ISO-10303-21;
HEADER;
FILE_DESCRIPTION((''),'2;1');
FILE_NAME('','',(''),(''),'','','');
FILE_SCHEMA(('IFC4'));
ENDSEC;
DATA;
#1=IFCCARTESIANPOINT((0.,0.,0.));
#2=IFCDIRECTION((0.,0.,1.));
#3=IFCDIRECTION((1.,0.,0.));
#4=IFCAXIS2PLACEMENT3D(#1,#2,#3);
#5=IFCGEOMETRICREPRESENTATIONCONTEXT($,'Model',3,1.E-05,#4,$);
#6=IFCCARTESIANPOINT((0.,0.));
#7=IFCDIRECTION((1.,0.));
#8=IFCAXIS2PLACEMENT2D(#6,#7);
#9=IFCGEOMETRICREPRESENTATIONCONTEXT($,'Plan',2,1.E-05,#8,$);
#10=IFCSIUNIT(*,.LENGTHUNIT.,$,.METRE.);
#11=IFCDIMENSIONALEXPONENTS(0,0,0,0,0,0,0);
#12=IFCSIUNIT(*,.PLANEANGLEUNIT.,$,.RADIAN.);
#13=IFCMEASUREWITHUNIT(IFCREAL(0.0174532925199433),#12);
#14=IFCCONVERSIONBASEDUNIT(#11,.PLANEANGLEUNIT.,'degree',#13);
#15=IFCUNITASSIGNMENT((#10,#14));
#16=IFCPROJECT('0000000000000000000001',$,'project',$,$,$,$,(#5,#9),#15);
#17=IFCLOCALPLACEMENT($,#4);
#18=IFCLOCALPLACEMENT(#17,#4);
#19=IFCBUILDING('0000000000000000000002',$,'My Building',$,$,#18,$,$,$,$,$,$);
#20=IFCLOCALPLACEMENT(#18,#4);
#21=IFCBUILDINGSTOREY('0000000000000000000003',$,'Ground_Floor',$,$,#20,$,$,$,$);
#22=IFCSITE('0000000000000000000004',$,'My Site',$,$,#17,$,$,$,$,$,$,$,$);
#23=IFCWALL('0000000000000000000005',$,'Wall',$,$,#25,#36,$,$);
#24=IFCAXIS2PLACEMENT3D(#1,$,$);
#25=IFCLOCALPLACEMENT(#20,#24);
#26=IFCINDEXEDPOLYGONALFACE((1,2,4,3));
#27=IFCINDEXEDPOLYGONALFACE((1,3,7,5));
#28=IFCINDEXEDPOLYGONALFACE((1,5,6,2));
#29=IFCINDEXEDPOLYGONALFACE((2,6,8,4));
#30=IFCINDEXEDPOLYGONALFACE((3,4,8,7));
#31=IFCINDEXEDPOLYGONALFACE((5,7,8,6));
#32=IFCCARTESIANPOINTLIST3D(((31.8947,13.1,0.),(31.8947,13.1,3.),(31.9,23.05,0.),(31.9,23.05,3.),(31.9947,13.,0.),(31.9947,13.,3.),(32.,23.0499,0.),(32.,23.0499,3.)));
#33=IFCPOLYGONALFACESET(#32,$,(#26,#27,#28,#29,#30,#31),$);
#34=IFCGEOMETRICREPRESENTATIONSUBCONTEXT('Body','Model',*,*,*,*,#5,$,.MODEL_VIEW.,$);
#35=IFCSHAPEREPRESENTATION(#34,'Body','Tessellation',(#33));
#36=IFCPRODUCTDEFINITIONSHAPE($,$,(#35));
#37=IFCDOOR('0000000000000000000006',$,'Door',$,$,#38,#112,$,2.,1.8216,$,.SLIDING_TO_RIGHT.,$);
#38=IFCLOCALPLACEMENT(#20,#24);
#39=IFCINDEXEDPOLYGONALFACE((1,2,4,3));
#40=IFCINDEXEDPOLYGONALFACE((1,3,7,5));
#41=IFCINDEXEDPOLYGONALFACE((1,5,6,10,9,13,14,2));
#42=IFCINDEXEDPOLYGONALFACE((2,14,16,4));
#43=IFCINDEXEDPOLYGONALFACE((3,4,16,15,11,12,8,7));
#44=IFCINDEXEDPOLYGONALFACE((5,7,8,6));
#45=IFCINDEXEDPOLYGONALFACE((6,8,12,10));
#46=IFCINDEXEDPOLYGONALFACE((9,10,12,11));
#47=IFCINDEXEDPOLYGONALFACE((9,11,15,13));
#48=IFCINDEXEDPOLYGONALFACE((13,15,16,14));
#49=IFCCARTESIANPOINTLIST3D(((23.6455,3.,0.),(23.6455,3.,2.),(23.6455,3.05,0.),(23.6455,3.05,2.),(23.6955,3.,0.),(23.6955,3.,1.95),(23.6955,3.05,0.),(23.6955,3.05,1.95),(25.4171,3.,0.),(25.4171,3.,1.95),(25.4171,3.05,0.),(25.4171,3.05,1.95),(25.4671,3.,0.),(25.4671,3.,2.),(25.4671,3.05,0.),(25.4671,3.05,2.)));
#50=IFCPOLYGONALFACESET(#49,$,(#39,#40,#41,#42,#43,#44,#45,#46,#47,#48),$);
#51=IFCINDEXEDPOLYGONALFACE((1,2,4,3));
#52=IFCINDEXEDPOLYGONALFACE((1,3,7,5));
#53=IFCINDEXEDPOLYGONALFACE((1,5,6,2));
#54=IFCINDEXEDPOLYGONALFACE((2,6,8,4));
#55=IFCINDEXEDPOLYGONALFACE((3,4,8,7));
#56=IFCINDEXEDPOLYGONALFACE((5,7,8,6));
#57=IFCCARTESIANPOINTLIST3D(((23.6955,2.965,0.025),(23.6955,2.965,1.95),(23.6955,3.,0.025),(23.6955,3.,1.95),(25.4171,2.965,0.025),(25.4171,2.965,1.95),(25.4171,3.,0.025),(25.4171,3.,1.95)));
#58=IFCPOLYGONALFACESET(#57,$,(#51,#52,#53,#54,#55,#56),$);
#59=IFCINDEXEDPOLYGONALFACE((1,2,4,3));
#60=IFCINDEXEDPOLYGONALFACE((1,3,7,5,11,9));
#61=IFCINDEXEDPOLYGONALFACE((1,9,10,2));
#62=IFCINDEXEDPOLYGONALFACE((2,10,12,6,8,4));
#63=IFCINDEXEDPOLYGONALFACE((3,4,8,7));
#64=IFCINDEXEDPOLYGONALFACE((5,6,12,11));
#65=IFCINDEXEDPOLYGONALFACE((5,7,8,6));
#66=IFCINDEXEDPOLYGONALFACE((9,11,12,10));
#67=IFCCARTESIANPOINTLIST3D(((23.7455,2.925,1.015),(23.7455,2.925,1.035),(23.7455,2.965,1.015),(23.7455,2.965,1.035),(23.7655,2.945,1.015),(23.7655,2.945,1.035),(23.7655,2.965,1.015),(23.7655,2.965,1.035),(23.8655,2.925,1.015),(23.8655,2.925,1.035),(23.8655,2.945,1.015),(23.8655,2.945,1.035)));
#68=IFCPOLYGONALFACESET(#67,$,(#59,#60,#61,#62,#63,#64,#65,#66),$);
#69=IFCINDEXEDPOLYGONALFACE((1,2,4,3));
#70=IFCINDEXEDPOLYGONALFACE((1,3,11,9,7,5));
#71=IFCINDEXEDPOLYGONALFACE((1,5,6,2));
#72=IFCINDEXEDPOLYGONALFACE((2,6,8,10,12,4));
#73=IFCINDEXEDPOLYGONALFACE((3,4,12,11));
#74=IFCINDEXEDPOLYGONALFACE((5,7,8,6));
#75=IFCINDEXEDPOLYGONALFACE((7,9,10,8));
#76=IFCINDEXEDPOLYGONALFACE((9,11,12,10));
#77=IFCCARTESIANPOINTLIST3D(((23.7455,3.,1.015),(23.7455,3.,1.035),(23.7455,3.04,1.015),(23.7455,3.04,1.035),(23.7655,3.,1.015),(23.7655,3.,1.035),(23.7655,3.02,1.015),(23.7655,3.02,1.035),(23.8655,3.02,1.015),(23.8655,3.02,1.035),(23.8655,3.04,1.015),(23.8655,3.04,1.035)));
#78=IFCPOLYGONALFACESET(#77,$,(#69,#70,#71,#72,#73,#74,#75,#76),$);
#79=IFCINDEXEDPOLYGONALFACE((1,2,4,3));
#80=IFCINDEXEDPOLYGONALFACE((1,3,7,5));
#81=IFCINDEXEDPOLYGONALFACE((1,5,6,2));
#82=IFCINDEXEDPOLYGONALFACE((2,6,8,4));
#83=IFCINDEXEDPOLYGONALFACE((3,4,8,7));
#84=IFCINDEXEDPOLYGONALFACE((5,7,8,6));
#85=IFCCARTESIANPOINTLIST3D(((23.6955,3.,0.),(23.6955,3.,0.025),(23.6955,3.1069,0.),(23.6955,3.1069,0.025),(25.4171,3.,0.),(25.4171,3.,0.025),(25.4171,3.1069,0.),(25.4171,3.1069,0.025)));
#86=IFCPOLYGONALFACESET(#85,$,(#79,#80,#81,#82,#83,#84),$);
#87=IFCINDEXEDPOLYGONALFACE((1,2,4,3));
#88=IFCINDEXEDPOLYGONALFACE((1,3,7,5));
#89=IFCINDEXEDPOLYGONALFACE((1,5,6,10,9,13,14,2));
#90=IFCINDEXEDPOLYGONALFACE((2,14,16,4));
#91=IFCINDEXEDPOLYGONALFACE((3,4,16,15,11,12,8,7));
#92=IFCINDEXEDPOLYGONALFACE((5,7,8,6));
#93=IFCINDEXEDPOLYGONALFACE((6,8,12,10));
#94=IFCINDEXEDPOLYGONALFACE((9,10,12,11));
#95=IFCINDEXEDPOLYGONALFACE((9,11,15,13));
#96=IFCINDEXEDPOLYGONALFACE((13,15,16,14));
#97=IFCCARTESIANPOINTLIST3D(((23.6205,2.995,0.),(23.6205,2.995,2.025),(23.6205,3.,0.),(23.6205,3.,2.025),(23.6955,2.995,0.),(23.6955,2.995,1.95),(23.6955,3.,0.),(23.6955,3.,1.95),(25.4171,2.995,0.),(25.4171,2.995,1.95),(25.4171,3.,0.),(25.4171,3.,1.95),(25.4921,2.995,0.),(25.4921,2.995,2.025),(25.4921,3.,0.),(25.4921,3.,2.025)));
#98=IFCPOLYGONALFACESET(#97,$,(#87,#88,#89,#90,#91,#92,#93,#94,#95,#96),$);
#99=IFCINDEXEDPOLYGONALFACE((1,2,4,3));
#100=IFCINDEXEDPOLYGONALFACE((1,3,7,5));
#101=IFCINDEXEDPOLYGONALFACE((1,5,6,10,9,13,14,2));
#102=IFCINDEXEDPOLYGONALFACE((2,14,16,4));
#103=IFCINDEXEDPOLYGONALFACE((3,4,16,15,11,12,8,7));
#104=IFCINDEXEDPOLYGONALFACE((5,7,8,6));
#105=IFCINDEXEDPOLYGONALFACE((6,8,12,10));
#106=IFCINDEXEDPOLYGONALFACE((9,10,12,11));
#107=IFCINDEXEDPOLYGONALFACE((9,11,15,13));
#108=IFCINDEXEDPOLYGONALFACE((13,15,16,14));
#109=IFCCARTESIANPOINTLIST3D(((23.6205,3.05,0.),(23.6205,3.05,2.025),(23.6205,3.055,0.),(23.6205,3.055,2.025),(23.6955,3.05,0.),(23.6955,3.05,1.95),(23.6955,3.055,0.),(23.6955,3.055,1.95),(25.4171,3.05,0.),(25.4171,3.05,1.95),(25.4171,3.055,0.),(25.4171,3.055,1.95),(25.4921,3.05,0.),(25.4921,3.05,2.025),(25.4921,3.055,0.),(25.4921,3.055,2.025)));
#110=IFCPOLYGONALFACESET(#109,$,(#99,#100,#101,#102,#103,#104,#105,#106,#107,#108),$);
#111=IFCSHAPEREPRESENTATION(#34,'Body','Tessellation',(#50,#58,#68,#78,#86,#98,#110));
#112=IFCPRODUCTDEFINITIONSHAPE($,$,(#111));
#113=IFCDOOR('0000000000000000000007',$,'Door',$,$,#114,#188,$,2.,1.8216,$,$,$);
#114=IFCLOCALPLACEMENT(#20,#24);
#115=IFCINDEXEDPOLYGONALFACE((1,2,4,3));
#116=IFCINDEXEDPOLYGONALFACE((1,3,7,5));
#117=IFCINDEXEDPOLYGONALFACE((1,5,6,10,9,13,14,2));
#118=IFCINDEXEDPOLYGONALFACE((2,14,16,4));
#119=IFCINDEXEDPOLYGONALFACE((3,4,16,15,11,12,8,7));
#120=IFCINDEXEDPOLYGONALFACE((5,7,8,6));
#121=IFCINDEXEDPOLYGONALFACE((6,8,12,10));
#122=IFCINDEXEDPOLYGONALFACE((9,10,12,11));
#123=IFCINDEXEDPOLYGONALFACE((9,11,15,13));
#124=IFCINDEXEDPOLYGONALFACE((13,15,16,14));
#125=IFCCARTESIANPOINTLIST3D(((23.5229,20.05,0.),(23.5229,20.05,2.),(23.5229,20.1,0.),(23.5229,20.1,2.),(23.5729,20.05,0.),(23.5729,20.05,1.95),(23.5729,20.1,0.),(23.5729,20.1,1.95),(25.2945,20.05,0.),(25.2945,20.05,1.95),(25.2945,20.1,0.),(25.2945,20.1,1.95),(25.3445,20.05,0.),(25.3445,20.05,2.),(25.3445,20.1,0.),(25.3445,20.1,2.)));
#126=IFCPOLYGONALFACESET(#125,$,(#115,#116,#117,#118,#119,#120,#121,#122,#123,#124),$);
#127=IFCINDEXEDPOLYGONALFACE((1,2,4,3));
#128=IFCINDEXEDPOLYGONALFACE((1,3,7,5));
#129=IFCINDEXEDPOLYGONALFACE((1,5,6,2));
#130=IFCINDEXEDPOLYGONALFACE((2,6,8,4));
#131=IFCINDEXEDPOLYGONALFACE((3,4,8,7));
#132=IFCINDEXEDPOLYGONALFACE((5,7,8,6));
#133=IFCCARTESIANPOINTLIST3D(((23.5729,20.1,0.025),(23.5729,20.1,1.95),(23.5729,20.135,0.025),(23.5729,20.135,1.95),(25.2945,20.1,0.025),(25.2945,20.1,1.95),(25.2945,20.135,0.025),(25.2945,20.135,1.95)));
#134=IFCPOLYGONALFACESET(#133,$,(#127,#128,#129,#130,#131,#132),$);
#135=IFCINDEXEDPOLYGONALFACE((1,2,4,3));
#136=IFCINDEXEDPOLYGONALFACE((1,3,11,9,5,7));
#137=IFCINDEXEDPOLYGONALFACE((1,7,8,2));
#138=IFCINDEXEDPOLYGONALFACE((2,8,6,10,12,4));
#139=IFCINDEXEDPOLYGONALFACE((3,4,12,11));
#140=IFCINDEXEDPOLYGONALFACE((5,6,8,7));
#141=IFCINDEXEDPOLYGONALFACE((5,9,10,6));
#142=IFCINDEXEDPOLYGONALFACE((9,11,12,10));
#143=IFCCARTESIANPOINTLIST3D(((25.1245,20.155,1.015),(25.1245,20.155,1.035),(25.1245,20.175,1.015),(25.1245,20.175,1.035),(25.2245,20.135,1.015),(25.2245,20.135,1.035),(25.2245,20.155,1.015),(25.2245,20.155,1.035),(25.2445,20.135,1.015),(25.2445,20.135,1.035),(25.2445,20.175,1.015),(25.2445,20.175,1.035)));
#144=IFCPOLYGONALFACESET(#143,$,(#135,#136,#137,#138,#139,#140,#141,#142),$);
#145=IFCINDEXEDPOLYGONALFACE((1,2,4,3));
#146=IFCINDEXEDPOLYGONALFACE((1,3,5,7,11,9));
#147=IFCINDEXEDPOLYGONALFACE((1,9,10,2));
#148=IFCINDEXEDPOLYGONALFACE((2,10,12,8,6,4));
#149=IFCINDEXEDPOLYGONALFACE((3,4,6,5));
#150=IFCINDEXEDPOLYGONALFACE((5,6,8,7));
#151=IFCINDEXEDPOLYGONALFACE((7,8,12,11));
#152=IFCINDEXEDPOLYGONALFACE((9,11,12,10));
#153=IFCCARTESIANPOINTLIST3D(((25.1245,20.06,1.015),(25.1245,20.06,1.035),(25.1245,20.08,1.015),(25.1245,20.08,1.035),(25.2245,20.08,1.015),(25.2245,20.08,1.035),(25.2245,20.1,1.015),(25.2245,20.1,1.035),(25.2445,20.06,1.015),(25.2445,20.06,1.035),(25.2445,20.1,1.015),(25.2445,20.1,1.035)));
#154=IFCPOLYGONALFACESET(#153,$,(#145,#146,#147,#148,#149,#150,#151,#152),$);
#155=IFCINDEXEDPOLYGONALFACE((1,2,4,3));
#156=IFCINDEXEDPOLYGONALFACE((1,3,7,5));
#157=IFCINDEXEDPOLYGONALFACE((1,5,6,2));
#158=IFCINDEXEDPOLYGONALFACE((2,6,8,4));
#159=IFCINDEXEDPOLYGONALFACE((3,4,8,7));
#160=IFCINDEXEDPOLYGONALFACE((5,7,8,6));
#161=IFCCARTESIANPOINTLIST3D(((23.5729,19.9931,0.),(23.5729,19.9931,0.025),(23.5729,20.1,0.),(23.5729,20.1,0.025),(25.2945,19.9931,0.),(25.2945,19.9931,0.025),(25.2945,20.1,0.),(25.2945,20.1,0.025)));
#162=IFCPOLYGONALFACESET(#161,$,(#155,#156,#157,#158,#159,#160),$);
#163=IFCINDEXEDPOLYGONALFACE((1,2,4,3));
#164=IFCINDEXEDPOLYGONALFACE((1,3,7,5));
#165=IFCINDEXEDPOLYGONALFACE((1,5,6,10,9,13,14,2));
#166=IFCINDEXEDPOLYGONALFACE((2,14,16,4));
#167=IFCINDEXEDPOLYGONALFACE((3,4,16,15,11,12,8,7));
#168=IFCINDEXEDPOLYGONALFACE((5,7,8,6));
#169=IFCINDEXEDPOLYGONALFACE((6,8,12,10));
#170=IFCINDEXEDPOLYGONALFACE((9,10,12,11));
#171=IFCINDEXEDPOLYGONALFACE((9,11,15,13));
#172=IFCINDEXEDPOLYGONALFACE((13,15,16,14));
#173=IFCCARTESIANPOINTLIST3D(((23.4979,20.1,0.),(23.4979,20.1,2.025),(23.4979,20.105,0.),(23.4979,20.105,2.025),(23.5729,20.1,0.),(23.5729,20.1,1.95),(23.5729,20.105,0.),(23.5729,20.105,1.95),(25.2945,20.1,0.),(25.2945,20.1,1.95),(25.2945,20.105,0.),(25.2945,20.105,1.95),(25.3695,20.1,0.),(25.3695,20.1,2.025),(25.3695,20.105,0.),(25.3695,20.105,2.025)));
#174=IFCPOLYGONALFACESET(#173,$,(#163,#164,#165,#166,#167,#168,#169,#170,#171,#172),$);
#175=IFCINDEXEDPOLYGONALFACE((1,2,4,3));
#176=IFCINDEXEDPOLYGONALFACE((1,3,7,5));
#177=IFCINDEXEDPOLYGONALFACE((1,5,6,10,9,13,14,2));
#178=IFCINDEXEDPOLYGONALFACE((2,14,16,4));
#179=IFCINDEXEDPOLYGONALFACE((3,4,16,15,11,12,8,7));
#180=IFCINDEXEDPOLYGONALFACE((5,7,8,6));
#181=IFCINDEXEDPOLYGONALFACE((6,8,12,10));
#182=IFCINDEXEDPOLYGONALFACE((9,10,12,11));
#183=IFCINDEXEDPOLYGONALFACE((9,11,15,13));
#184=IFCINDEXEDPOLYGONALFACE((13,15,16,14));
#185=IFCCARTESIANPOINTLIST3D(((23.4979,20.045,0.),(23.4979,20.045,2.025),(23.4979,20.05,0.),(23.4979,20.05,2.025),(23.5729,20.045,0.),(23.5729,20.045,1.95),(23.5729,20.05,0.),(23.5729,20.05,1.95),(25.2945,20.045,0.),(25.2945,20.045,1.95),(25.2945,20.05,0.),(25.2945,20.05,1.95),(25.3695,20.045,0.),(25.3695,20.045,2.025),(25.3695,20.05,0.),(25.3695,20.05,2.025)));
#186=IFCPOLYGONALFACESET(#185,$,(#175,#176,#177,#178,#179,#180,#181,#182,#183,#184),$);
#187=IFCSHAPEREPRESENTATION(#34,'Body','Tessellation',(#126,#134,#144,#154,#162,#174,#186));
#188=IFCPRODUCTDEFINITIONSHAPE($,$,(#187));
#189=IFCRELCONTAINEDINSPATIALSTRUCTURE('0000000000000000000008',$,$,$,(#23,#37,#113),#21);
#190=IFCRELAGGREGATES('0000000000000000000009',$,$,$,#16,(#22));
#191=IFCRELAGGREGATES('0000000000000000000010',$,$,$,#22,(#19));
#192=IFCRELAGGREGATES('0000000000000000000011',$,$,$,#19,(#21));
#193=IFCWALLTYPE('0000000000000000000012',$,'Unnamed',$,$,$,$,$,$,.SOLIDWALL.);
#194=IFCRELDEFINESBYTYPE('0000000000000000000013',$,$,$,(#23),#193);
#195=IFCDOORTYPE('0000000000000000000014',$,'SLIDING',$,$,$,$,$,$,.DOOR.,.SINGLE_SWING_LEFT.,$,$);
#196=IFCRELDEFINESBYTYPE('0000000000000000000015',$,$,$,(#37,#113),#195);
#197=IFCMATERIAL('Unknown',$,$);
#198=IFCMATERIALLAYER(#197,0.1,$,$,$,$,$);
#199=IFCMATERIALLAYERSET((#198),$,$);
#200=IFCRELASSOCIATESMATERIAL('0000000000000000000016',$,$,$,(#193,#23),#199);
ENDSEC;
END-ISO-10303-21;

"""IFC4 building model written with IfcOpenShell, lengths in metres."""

from ifc_helpers import new_model, entity, si_unit, converted_unit, frame, origin_with_axes, origin_2d_with_axis, place, context, subcontext, project, spatial, line, indexed_curve, outline, extrude, shape, source, transform, mapped, material, layer, layer_set, layer_usage, type_object, type_shapes, element, save


model = new_model("IFC4")

# Units and contexts
model_context = context("Model", 3, precision=1e-05, world=origin_with_axes())
plan_context = context("Plan", 2, precision=1e-05, world=origin_2d_with_axis())
body_context_1 = subcontext(model_context, "Body", "Model", "MODEL_VIEW")
body_context_2 = subcontext(plan_context, "Body", "Plan", "PLAN_VIEW")
ifc_project = project(units=[si_unit("LENGTHUNIT", "METRE"), converted_unit("PLANEANGLEUNIT", "degree", entity("IfcReal", 0.0174532925199433), si_unit("PLANEANGLEUNIT", "RADIAN"), dimensions=[0, 0, 0, 0, 0, 0, 0])], contexts=[model_context, plan_context])

# Site, building, storey
site_placement = place(None, origin_with_axes())
site = spatial("IfcSite", under=ifc_project, at=site_placement, Name="My Site")
building_placement = place(site_placement, origin_with_axes())
building = spatial("IfcBuilding", under=site, at=building_placement, Name="My Building")
storey_placement = place(building_placement, origin_with_axes())
storey = spatial("IfcBuildingStorey", under=building, at=storey_placement, Name="Ground_Floor")

# Shared definitions
ifc_material = material(Name="Unknown")
ifc_layer = layer(ifc_material, 0.1)
ifc_layer_set = layer_set([ifc_layer])
wall_type = type_object("IfcWallType", Name="Unnamed", PredefinedType="SOLIDWALL", material=ifc_layer_set)

# Shared definitions
door_type_1 = type_object("IfcDoorType", Name="SLIDING", OperationType="SINGLE_SWING_LEFT", PredefinedType="DOOR")
shared_shape_1 = source(origin_with_axes(), body_context_1, "Body", "SweptSolid", [
    extrude(outline(indexed_curve([(0.0, 0.0), (0.0, 2.0), (1.8216, 2.0), (1.8216, 0.0), (1.7716, 0.0), (1.7716, 1.95), (0.05, 1.95), (0.05, 0.0)], segments=[line(1, 2, 3, 4, 5, 6, 7, 8, 1)])), frame((0.0, 0.0, 0.0), z_axis=(0.0, -1.0, 0.0), x_axis=(1.0, 0.0, 0.0)), (0.0, 0.0, -1.0), 0.05),
    extrude(outline(indexed_curve([(0.0, 0.0), (1.7216, 0.0), (1.7216, 0.035), (0.0, 0.035)], segments=[line(1, 2, 3, 4, 1)])), frame((0.05, -0.035, 0.025), z_axis=(0.0, 0.0, 1.0), x_axis=(1.0, 0.0, 0.0)), (0.0, 0.0, 1.0), 1.925),
    extrude(outline(indexed_curve([(0.0, 0.0), (0.0, -0.04), (0.12, -0.04), (0.12, -0.02), (0.02, -0.02), (0.02, 0.0)], segments=[line(1, 2, 3, 4, 5, 6, 1)])), frame((0.1, -0.035, 1.015), z_axis=(0.0, 0.0, 1.0), x_axis=(1.0, 0.0, 0.0)), (0.0, 0.0, 1.0), 0.02),
    extrude(outline(indexed_curve([(0.0, 0.0), (0.0, 0.04), (0.12, 0.04), (0.12, 0.02), (0.02, 0.02), (0.02, 0.0)], segments=[line(1, 2, 3, 4, 5, 6, 1)])), frame((0.1, 0.0, 1.015), z_axis=(0.0, 0.0, 1.0), x_axis=(1.0, 0.0, 0.0)), (0.0, 0.0, 1.0), 0.02),
    extrude(outline(indexed_curve([(0.0, 0.0), (1.7216, 0.0), (1.7216, 0.1069), (0.0, 0.1069)], segments=[line(1, 2, 3, 4, 1)])), frame((0.05, 0.0, 0.0), z_axis=(0.0, 0.0, 1.0), x_axis=(1.0, 0.0, 0.0)), (0.0, 0.0, 1.0), 0.025),
    extrude(outline(indexed_curve([(0.0, 0.0), (0.0, 2.025), (1.8716, 2.025), (1.8716, 0.0), (1.7966, 0.0), (1.7966, 1.95), (0.075, 1.95), (0.075, 0.0)], segments=[line(1, 2, 3, 4, 5, 6, 7, 8, 1)])), frame((-0.025, -0.005, 0.0), z_axis=(0.0, -1.0, 0.0), x_axis=(1.0, 0.0, 0.0)), (0.0, 0.0, -1.0), 0.005),
    extrude(outline(indexed_curve([(0.0, 0.0), (0.0, 2.025), (1.8716, 2.025), (1.8716, 0.0), (1.7966, 0.0), (1.7966, 1.95), (0.075, 1.95), (0.075, 0.0)], segments=[line(1, 2, 3, 4, 5, 6, 7, 8, 1)])), frame((-0.025, 0.05, 0.0), z_axis=(0.0, -1.0, 0.0), x_axis=(1.0, 0.0, 0.0)), (0.0, 0.0, -1.0), 0.005),
])
shared_shape_2 = source(origin_with_axes(), body_context_2, "Body", "Curve2D", [
    entity("IfcIndexedPolyCurve", entity("IfcCartesianPointList2D", [[0.0, 0.0], [0.05, 0.0], [0.05, 0.05], [0.0, 0.05]]), [entity("IfcLineIndex", [1, 2, 3, 4, 1])]),
    entity("IfcIndexedPolyCurve", entity("IfcCartesianPointList2D", [[1.8216, 0.0], [1.7716, 0.0], [1.7716, 0.05], [1.8216, 0.05]]), [entity("IfcLineIndex", [1, 2, 3, 4, 1])]),
    entity("IfcIndexedPolyCurve", entity("IfcCartesianPointList2D", [[2.6325, -0.035], [0.9108, -0.035], [0.9108, 0.0], [2.6325, 0.0]]), [entity("IfcLineIndex", [1, 2, 3, 4, 1])]),
])
type_shapes(door_type_1, [shared_shape_1, shared_shape_2])

# Wall
ifc_layer_usage_1 = layer_usage(ifc_layer_set, "AXIS2", "POSITIVE", 0.0)
wall_1_placement = place(storey_placement, frame((31.9, 23.05, 0.0), z_axis=(0.0, 0.0, 1.0), x_axis=(-0.000532, -1.0, 0.0)))
element("IfcWall", 1, at=wall_1_placement, inside=storey, type_object=wall_type, material=ifc_layer_usage_1, Name="Wall", context=body_context_1, shape_type="SweptSolid", body=[
    extrude(outline(indexed_curve([(0.0, 0.0), (0.0, 0.1), (10.0499, 0.1), (9.95, 0.0)], segments=[line(1, 2, 3, 4, 1)])), origin_with_axes(), (0.0, 0.0, 1.0), 3.0),
])

# Doors
door_1_placement = place(storey_placement, frame((23.6455, 3.0, 0.0), z_axis=(0.0, 0.0, 1.0), x_axis=(1.0, 0.0, 0.0)))
element("IfcDoor", 2, at=door_1_placement, inside=storey, type_object=door_type_1, Name="Door", OperationType="SLIDING_TO_RIGHT", OverallHeight=2.0, OverallWidth=1.8216, shapes=[
    shape(body_context_1, "Body", "MappedRepresentation", [mapped(shared_shape_1, transform((0.0, 0.0, 0.0), x_axis=(1.0, 0.0, 0.0), y_axis=(0.0, 1.0, 0.0), z_axis=(0.0, 0.0, 1.0), scale=1.0))]),
    shape(body_context_2, "Body", "MappedRepresentation", [mapped(shared_shape_2, transform((0.0, 0.0, 0.0), x_axis=(1.0, 0.0, 0.0), y_axis=(0.0, 1.0, 0.0), z_axis=(0.0, 0.0, 1.0), scale=1.0))]),
])
door_2_placement = place(storey_placement, frame((25.3445, 20.1, 0.0), z_axis=(0.0, 0.0, 1.0), x_axis=(-1.0, 0.0, 0.0)))
element("IfcDoor", 3, at=door_2_placement, inside=storey, type_object=door_type_1, Name="Door", OverallHeight=2.0, OverallWidth=1.8216, shapes=[
    shape(body_context_1, "Body", "MappedRepresentation", [mapped(shared_shape_1, transform((0.0, 0.0, 0.0), x_axis=(1.0, 0.0, 0.0), y_axis=(0.0, 1.0, 0.0), z_axis=(0.0, 0.0, 1.0), scale=1.0))]),
    shape(body_context_2, "Body", "MappedRepresentation", [mapped(shared_shape_2, transform((0.0, 0.0, 0.0), x_axis=(1.0, 0.0, 0.0), y_axis=(0.0, 1.0, 0.0), z_axis=(0.0, 0.0, 1.0), scale=1.0))]),
])

save(model, "model.ifc")
